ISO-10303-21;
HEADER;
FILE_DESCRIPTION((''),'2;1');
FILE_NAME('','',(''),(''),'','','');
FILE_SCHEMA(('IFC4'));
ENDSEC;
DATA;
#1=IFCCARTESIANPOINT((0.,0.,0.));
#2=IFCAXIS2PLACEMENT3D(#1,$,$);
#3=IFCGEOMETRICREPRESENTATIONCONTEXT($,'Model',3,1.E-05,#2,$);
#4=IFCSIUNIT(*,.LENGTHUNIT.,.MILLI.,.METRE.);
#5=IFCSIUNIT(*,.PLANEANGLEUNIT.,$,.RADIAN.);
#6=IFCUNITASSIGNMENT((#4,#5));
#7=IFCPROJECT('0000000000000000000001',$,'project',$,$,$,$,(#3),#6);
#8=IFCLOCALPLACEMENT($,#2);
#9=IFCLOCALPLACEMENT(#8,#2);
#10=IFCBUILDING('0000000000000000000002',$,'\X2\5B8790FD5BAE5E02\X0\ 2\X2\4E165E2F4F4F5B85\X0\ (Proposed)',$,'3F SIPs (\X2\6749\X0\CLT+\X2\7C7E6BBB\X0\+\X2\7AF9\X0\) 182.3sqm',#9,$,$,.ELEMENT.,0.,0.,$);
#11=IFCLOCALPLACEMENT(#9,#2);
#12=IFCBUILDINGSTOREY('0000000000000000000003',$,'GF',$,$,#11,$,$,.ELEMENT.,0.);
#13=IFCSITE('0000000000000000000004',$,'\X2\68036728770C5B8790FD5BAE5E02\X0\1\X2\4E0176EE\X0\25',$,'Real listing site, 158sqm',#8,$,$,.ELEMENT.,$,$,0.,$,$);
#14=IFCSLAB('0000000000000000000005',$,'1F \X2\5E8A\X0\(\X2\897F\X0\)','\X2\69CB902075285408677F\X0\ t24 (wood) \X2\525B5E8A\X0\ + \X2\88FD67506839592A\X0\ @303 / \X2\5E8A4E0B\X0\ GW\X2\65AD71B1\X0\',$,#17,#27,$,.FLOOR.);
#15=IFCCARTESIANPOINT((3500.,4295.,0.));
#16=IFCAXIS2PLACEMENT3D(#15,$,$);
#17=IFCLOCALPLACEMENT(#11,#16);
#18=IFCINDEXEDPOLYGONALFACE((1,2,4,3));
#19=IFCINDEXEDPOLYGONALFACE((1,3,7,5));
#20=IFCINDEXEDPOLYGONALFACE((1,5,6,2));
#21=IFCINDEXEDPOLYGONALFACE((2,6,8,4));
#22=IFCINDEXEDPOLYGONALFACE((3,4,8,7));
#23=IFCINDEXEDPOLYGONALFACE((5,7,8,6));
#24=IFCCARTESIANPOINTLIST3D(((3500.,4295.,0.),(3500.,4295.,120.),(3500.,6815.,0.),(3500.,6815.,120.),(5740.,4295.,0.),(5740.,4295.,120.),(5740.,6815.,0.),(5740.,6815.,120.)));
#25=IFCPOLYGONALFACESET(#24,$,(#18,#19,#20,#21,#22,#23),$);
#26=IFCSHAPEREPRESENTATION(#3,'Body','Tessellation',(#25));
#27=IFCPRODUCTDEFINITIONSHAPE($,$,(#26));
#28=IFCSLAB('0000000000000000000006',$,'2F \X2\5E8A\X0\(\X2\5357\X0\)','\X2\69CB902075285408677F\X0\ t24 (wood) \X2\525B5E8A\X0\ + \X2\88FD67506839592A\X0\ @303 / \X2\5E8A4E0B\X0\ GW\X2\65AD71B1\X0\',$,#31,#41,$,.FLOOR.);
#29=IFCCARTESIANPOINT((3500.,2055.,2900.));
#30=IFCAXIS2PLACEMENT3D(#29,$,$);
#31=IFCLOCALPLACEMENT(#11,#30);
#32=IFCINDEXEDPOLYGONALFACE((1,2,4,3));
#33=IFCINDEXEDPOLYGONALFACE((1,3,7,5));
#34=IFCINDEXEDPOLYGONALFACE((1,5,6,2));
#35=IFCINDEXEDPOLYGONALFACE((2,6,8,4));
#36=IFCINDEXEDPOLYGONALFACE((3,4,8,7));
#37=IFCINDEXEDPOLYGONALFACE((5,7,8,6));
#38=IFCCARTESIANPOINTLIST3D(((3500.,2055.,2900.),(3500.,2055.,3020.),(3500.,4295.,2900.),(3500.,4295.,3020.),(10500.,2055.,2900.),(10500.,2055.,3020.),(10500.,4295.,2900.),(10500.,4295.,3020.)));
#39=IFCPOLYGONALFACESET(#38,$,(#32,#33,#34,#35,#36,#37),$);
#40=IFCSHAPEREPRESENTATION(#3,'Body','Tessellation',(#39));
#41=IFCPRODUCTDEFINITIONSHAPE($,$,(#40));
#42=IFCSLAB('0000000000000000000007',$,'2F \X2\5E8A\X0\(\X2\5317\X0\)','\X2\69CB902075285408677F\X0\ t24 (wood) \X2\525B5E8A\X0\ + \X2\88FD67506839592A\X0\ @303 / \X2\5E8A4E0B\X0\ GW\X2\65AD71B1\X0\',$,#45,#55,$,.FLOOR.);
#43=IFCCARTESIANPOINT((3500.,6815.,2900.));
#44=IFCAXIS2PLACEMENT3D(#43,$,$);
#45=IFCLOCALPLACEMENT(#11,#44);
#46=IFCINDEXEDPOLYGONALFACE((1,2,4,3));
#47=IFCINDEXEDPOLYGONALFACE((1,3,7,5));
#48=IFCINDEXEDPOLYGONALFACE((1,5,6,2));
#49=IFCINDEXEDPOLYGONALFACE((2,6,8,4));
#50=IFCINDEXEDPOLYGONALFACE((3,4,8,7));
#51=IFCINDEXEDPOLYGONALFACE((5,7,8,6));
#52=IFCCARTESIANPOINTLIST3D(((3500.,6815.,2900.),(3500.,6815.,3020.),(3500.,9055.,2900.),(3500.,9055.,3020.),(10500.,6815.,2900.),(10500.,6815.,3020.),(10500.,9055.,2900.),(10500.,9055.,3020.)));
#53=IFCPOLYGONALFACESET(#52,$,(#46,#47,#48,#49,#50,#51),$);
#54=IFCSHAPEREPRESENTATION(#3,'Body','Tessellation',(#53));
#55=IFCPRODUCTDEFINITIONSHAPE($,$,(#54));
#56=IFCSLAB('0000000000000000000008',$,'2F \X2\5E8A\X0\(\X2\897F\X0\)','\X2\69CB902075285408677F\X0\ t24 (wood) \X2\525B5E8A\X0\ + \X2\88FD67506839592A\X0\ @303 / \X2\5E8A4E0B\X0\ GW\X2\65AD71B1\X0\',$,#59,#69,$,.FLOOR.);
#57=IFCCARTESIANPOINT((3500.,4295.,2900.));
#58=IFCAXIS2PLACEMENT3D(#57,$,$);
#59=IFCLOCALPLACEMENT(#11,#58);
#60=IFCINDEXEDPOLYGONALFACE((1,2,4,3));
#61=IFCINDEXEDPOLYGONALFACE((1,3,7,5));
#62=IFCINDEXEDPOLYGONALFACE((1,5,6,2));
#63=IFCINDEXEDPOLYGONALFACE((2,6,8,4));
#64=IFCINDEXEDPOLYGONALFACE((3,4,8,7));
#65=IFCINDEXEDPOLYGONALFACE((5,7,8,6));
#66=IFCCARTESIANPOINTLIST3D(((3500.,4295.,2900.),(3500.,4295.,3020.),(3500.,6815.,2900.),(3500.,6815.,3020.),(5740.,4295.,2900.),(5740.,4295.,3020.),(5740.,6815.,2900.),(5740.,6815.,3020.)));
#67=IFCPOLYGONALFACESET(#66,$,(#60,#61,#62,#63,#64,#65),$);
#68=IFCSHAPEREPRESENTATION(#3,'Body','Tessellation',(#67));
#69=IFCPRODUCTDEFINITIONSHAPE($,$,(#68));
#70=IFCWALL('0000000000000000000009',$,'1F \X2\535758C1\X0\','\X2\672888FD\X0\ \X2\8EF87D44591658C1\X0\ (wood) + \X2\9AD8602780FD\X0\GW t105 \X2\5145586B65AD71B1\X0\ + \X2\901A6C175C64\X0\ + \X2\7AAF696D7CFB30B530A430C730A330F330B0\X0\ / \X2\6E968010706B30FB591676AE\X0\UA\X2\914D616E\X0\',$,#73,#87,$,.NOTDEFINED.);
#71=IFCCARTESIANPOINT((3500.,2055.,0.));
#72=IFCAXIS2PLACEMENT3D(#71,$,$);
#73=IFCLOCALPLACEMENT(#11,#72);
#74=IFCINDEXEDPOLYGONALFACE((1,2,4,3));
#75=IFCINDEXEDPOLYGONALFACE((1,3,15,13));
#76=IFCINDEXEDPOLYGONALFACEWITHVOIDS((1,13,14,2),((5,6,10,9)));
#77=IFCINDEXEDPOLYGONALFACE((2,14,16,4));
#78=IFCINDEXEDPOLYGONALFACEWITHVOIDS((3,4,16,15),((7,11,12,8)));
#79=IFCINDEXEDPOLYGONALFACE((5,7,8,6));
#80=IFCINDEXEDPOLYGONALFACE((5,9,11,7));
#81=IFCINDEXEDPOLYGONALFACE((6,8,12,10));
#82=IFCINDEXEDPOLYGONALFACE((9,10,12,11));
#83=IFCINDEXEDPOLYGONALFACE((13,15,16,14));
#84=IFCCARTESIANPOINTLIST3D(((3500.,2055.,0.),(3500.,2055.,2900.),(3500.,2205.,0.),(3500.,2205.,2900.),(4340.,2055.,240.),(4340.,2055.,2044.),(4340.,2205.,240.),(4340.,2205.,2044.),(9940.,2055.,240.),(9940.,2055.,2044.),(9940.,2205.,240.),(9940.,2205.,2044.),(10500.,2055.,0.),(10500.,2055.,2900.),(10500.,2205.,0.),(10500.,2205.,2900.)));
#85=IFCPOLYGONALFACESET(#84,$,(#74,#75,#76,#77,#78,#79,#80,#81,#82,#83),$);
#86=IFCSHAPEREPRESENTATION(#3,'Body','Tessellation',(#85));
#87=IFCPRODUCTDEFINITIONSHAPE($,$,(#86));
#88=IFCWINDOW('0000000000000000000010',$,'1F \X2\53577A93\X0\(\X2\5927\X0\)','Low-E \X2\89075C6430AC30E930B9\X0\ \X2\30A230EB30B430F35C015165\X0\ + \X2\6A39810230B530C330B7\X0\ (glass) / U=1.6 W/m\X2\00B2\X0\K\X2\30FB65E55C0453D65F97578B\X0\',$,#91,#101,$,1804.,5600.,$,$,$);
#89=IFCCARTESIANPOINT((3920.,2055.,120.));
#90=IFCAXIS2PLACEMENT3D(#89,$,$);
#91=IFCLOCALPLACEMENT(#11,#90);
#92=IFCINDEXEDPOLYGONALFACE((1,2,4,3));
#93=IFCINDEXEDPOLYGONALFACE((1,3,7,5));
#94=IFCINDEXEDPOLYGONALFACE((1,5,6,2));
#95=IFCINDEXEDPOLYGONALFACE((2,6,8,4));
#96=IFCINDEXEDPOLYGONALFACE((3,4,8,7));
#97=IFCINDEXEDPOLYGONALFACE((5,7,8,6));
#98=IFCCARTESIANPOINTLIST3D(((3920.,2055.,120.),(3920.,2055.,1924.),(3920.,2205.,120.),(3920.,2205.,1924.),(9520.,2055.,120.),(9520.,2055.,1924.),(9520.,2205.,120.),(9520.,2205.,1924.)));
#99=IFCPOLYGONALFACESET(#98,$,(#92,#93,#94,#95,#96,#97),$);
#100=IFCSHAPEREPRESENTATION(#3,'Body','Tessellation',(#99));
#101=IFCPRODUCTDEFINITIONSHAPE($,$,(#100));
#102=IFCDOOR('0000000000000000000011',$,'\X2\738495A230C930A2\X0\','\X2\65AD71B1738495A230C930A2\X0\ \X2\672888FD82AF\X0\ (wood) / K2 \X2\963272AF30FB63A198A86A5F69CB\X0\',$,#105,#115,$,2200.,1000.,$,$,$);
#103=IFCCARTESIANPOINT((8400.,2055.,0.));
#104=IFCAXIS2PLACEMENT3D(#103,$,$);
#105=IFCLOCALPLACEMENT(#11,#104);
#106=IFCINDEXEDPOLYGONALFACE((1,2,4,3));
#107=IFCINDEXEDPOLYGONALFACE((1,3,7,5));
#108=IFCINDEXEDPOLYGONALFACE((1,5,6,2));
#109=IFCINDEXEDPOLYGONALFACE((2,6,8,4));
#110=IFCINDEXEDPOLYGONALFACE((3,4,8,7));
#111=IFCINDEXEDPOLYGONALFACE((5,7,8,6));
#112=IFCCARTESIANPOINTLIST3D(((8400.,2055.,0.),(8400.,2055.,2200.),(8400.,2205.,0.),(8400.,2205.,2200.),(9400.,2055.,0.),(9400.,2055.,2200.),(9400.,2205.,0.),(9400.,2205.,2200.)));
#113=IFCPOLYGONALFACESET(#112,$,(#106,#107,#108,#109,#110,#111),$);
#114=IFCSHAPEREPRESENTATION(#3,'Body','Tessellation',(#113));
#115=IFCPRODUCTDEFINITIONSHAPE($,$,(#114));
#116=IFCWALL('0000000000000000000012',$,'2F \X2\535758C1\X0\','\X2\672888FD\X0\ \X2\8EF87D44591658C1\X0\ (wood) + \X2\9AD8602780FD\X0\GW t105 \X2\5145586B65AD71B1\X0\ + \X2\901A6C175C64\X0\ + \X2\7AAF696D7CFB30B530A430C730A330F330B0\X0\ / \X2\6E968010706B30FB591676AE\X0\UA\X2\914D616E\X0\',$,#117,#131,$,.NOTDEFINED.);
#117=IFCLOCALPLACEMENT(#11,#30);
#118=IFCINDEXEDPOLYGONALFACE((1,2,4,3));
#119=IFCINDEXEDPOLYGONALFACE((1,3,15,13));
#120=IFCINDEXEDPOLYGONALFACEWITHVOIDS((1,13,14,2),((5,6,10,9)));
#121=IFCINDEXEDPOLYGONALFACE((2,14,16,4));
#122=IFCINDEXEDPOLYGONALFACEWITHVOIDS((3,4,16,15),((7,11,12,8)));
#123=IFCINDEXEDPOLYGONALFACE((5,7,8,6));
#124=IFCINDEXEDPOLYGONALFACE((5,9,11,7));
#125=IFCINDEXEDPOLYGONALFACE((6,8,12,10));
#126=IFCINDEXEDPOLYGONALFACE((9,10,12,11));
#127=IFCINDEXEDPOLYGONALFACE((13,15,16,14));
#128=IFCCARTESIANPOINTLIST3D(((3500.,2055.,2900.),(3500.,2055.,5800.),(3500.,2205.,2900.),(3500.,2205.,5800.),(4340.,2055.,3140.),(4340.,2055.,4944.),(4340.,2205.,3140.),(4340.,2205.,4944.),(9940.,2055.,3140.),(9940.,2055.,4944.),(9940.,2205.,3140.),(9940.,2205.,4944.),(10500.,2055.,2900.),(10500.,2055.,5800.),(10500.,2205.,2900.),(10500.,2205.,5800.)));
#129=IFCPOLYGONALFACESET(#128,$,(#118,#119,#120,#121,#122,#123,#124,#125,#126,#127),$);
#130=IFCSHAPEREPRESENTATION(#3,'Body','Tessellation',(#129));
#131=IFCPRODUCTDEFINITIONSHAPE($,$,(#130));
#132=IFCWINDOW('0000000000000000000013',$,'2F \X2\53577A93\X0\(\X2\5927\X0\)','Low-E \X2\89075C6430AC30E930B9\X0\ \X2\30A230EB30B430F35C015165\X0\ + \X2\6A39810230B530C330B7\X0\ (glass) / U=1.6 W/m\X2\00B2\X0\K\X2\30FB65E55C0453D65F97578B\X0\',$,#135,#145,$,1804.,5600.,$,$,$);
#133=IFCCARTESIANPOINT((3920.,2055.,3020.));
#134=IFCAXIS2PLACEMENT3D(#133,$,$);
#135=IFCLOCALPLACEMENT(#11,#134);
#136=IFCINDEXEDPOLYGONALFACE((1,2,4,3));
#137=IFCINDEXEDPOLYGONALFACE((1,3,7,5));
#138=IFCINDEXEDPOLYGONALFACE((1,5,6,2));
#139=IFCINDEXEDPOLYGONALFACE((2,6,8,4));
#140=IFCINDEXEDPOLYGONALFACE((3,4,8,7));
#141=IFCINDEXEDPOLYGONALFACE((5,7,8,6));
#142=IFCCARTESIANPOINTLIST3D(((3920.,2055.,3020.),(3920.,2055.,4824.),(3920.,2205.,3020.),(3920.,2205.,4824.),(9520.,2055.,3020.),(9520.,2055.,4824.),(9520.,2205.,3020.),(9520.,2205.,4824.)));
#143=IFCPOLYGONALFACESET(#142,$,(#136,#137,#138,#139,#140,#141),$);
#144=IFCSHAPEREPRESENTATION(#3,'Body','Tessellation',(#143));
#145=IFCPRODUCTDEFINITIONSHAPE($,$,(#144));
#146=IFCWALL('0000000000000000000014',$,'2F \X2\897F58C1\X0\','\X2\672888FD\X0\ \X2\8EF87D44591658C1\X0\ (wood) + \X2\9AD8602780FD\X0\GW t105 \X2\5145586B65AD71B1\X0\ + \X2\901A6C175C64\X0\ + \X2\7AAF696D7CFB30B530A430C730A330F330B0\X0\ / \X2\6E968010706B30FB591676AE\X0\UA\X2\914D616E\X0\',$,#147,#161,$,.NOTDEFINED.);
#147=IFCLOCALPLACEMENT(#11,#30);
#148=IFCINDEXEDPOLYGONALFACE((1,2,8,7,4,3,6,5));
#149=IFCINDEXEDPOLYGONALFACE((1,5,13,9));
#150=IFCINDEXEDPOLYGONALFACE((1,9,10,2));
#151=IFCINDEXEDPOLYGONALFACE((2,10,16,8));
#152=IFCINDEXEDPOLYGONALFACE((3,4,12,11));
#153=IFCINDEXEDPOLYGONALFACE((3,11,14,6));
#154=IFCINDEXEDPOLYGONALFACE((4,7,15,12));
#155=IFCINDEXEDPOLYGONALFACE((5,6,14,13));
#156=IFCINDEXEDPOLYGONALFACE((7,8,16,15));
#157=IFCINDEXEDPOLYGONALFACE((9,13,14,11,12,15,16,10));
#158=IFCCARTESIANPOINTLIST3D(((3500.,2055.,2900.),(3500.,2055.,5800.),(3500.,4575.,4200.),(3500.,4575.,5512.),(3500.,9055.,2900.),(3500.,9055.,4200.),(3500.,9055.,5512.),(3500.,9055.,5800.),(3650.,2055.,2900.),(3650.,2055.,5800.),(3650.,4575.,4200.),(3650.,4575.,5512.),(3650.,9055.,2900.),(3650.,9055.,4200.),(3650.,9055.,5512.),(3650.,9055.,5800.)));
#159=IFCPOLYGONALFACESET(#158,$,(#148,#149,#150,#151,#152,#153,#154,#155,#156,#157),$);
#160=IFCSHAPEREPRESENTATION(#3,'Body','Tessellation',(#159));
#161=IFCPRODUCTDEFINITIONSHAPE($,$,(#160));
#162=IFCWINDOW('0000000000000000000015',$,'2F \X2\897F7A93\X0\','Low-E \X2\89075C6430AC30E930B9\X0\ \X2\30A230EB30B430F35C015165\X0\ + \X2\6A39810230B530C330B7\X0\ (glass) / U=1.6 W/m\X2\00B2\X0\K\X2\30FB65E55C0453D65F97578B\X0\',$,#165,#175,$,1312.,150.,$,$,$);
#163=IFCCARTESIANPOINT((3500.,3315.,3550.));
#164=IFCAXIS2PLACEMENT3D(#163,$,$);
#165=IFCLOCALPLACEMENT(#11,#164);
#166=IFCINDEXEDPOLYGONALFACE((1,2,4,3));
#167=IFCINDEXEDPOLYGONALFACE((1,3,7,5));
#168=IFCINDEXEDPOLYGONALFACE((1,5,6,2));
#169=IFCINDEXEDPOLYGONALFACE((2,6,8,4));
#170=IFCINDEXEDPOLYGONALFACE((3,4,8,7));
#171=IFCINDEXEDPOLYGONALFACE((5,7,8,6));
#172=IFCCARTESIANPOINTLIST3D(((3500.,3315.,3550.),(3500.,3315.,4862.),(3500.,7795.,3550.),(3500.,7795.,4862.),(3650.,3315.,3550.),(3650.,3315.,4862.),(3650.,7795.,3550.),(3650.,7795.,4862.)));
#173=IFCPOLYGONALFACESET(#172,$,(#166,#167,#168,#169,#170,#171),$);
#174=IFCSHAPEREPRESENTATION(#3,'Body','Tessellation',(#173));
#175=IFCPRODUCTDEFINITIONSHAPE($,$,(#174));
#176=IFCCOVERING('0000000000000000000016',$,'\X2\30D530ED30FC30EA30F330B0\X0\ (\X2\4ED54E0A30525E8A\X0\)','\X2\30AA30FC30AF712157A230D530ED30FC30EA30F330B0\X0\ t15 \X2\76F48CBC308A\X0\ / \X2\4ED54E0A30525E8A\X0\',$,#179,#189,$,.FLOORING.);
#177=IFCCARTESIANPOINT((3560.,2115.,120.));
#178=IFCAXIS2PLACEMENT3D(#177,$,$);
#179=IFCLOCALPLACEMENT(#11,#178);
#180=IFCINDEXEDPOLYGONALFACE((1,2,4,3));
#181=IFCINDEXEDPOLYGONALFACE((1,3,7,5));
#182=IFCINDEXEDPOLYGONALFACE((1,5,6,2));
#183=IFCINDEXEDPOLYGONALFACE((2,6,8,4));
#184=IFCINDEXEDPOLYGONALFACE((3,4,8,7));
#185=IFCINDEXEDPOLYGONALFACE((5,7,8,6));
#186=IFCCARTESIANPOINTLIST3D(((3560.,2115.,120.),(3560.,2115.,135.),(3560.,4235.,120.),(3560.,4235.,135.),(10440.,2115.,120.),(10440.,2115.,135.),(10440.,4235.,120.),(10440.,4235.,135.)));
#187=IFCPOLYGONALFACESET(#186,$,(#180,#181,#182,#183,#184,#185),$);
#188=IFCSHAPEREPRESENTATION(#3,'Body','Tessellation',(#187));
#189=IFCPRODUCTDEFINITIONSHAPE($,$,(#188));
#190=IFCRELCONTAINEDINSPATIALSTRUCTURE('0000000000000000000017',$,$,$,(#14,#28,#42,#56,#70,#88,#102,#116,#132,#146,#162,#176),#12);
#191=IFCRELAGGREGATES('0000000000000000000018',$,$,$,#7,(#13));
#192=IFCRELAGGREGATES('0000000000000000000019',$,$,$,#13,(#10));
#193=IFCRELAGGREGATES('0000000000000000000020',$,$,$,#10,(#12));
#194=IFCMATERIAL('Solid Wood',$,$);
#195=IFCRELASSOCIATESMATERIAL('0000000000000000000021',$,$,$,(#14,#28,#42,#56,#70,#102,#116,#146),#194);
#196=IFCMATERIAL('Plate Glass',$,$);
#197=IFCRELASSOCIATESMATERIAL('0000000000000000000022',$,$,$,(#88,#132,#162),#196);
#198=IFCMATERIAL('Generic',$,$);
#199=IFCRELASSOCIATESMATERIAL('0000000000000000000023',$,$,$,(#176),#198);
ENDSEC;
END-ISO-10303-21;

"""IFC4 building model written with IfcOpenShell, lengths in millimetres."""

from ifc_helpers import new_model, si_unit, frame, frame_2d, origin, place, context, project, spatial, rectangle, extrude, material, element, fill, save


model = new_model("IFC4")

# Units and contexts
model_context = context("Model", 3, precision=1e-05, world=origin())
ifc_project = project(units=[si_unit("LENGTHUNIT", "METRE", prefix="MILLI"), si_unit("PLANEANGLEUNIT", "RADIAN")], contexts=[model_context])

# Site, building, storey
site_placement = place(None, origin())
site = spatial("IfcSite", under=ifc_project, at=site_placement, Name="栃木県宇都宮市1丁目25", ObjectType="Real listing site, 158sqm", CompositionType="ELEMENT", RefElevation=0.0)
building_placement = place(site_placement, origin())
building = spatial("IfcBuilding", under=site, at=building_placement, Name="宇都宮市 2世帯住宅 (Proposed)", ObjectType="3F SIPs (杉CLT+籾殻+竹) 182.3sqm", CompositionType="ELEMENT", ElevationOfRefHeight=0.0, ElevationOfTerrain=0.0)
storey_placement = place(building_placement, origin())
storey = spatial("IfcBuildingStorey", under=building, at=storey_placement, Name="GF", CompositionType="ELEMENT", Elevation=0.0)

# Slabs
ifc_material_1 = material(Name="Solid Wood")
slab_1_placement = place(storey_placement, frame((3500.0, 4295.0, 0.0)))
element("IfcSlab", 1, at=slab_1_placement, inside=storey, material=ifc_material_1, Name="1F 床(西)", Description="構造用合板 t24 (wood) 剛床 + 製材根太 @303 / 床下 GW断熱", PredefinedType="FLOOR", context=model_context, shape_type="SweptSolid", body=[
    extrude(rectangle(XDim=2240.0, YDim=2520.0, at=frame_2d((1120.0, 1260.0))), frame((3500.0, 4295.0, 0.0)), (0.0, 0.0, 1.0), 120.0),
])
slab_2_placement = place(storey_placement, frame((3500.0, 2055.0, 2900.0)))
element("IfcSlab", 2, at=slab_2_placement, inside=storey, material=ifc_material_1, Name="2F 床(南)", Description="構造用合板 t24 (wood) 剛床 + 製材根太 @303 / 床下 GW断熱", PredefinedType="FLOOR", context=model_context, shape_type="SweptSolid", body=[
    extrude(rectangle(XDim=7000.0, YDim=2240.0, at=frame_2d((3500.0, 1120.0))), frame((3500.0, 2055.0, 2900.0)), (0.0, 0.0, 1.0), 120.0),
])
slab_3_placement = place(storey_placement, frame((3500.0, 6815.0, 2900.0)))
element("IfcSlab", 3, at=slab_3_placement, inside=storey, material=ifc_material_1, Name="2F 床(北)", Description="構造用合板 t24 (wood) 剛床 + 製材根太 @303 / 床下 GW断熱", PredefinedType="FLOOR", context=model_context, shape_type="SweptSolid", body=[
    extrude(rectangle(XDim=7000.0, YDim=2240.0, at=frame_2d((3500.0, 1120.0))), frame((3500.0, 6815.0, 2900.0)), (0.0, 0.0, 1.0), 120.0),
])
slab_4_placement = place(storey_placement, frame((3500.0, 4295.0, 2900.0)))
element("IfcSlab", 4, at=slab_4_placement, inside=storey, material=ifc_material_1, Name="2F 床(西)", Description="構造用合板 t24 (wood) 剛床 + 製材根太 @303 / 床下 GW断熱", PredefinedType="FLOOR", context=model_context, shape_type="SweptSolid", body=[
    extrude(rectangle(XDim=2240.0, YDim=2520.0, at=frame_2d((1120.0, 1260.0))), frame((3500.0, 4295.0, 2900.0)), (0.0, 0.0, 1.0), 120.0),
])

# Wall, openings, window, door
wall_1_placement = place(storey_placement, frame((3500.0, 2055.0, 0.0)))
wall_1 = element("IfcWall", 5, at=wall_1_placement, inside=storey, material=ifc_material_1, Name="1F 南壁", Description="木製 軸組外壁 (wood) + 高性能GW t105 充填断熱 + 通気層 + 窯業系サイディング / 準耐火・外皮UA配慮", PredefinedType="NOTDEFINED", context=model_context, shape_type="SweptSolid", body=[
    extrude(rectangle(XDim=7000.0, YDim=150.0, at=frame_2d((3500.0, 75.0))), frame((3500.0, 2055.0, 0.0)), (0.0, 0.0, 1.0), 2900.0),
])
opening_1_placement = place(storey_placement, frame((3920.0, 2055.0, 120.0)))
opening_1 = element("IfcOpeningElement", 6, at=opening_1_placement, cuts=wall_1, PredefinedType="NOTDEFINED", context=model_context, shape_type="SweptSolid", body=[
    extrude(rectangle(XDim=5600.0, YDim=150.0, at=frame_2d((2800.0, 75.0))), frame((3920.0, 2055.0, 120.0)), (0.0, 0.0, 1.0), 1804.0),
])
opening_2_placement = place(storey_placement, frame((8400.0, 2055.0, 0.0)))
opening_2 = element("IfcOpeningElement", 7, at=opening_2_placement, cuts=wall_1, PredefinedType="NOTDEFINED", context=model_context, shape_type="SweptSolid", body=[
    extrude(rectangle(XDim=1000.0, YDim=150.0, at=frame_2d((500.0, 75.0))), frame((8400.0, 2055.0, 0.0)), (0.0, 0.0, 1.0), 2200.0),
])
ifc_material_2 = material(Name="Plate Glass")
window_1_placement = place(storey_placement, frame((3920.0, 2055.0, 120.0)))
window_1 = element("IfcWindow", 8, at=window_1_placement, inside=storey, material=ifc_material_2, Name="1F 南窓(大)", Description="Low-E 複層ガラス アルゴン封入 + 樹脂サッシ (glass) / U=1.6 W/m²K・日射取得型", OverallHeight=1804.0, OverallWidth=5600.0, context=model_context, shape_type="SweptSolid", body=[
    extrude(rectangle(XDim=5600.0, YDim=150.0, at=frame_2d((2800.0, 75.0))), frame((3920.0, 2055.0, 120.0)), (0.0, 0.0, 1.0), 1804.0),
])
fill(opening_1, window_1)
door_placement = place(storey_placement, frame((8400.0, 2055.0, 0.0)))
door = element("IfcDoor", 9, at=door_placement, inside=storey, material=ifc_material_1, Name="玄関ドア", Description="断熱玄関ドア 木製芯 (wood) / K2 防犯・採風機構", OverallHeight=2200.0, OverallWidth=1000.0, context=model_context, shape_type="SweptSolid", body=[
    extrude(rectangle(XDim=1000.0, YDim=150.0, at=frame_2d((500.0, 75.0))), frame((8400.0, 2055.0, 0.0)), (0.0, 0.0, 1.0), 2200.0),
])
fill(opening_2, door)

# Wall, opening, window
wall_2_placement = place(storey_placement, frame((3500.0, 2055.0, 2900.0)))
wall_2 = element("IfcWall", 10, at=wall_2_placement, inside=storey, material=ifc_material_1, Name="2F 南壁", Description="木製 軸組外壁 (wood) + 高性能GW t105 充填断熱 + 通気層 + 窯業系サイディング / 準耐火・外皮UA配慮", PredefinedType="NOTDEFINED", context=model_context, shape_type="SweptSolid", body=[
    extrude(rectangle(XDim=7000.0, YDim=150.0, at=frame_2d((3500.0, 75.0))), frame((3500.0, 2055.0, 2900.0)), (0.0, 0.0, 1.0), 2900.0),
])
opening_3_placement = place(storey_placement, frame((3920.0, 2055.0, 3020.0)))
opening_3 = element("IfcOpeningElement", 11, at=opening_3_placement, cuts=wall_2, PredefinedType="NOTDEFINED", context=model_context, shape_type="SweptSolid", body=[
    extrude(rectangle(XDim=5600.0, YDim=150.0, at=frame_2d((2800.0, 75.0))), frame((3920.0, 2055.0, 3020.0)), (0.0, 0.0, 1.0), 1804.0),
])
window_2_placement = place(storey_placement, frame((3920.0, 2055.0, 3020.0)))
window_2 = element("IfcWindow", 12, at=window_2_placement, inside=storey, material=ifc_material_2, Name="2F 南窓(大)", Description="Low-E 複層ガラス アルゴン封入 + 樹脂サッシ (glass) / U=1.6 W/m²K・日射取得型", OverallHeight=1804.0, OverallWidth=5600.0, context=model_context, shape_type="SweptSolid", body=[
    extrude(rectangle(XDim=5600.0, YDim=150.0, at=frame_2d((2800.0, 75.0))), frame((3920.0, 2055.0, 3020.0)), (0.0, 0.0, 1.0), 1804.0),
])
fill(opening_3, window_2)

# Wall, opening, window
wall_3_placement = place(storey_placement, frame((3500.0, 2055.0, 2900.0)))
wall_3 = element("IfcWall", 13, at=wall_3_placement, inside=storey, material=ifc_material_1, Name="2F 西壁", Description="木製 軸組外壁 (wood) + 高性能GW t105 充填断熱 + 通気層 + 窯業系サイディング / 準耐火・外皮UA配慮", PredefinedType="NOTDEFINED", context=model_context, shape_type="SweptSolid", body=[
    extrude(rectangle(XDim=150.0, YDim=7000.0, at=frame_2d((75.0, 3500.0))), frame((3500.0, 2055.0, 2900.0)), (0.0, 0.0, 1.0), 2900.0),
])
opening_4_placement = place(storey_placement, frame((3500.0, 3315.0, 3550.0)))
opening_4 = element("IfcOpeningElement", 14, at=opening_4_placement, cuts=wall_3, PredefinedType="NOTDEFINED", context=model_context, shape_type="SweptSolid", body=[
    extrude(rectangle(XDim=150.0, YDim=4480.0, at=frame_2d((75.0, 2240.0))), frame((3500.0, 3315.0, 3550.0)), (0.0, 0.0, 1.0), 1312.0),
])
window_3_placement = place(storey_placement, frame((3500.0, 3315.0, 3550.0)))
window_3 = element("IfcWindow", 15, at=window_3_placement, inside=storey, material=ifc_material_2, Name="2F 西窓", Description="Low-E 複層ガラス アルゴン封入 + 樹脂サッシ (glass) / U=1.6 W/m²K・日射取得型", OverallHeight=1312.0, OverallWidth=150.0, context=model_context, shape_type="SweptSolid", body=[
    extrude(rectangle(XDim=150.0, YDim=4480.0, at=frame_2d((75.0, 2240.0))), frame((3500.0, 3315.0, 3550.0)), (0.0, 0.0, 1.0), 1312.0),
])
fill(opening_4, window_3)

# Covering
ifc_material_3 = material(Name="Generic")
covering_1_placement = place(storey_placement, frame((3560.0, 2115.0, 120.0)))
element("IfcCovering", 16, at=covering_1_placement, inside=storey, material=ifc_material_3, Name="フローリング (仕上げ床)", Description="オーク無垢フローリング t15 直貼り / 仕上げ床", PredefinedType="FLOORING", context=model_context, shape_type="SweptSolid", body=[
    extrude(rectangle(XDim=6880.0, YDim=2120.0, at=frame_2d((3440.0, 1060.0))), frame((3560.0, 2115.0, 120.0)), (0.0, 0.0, 1.0), 15.0),
])

save(model, "model.ifc")
